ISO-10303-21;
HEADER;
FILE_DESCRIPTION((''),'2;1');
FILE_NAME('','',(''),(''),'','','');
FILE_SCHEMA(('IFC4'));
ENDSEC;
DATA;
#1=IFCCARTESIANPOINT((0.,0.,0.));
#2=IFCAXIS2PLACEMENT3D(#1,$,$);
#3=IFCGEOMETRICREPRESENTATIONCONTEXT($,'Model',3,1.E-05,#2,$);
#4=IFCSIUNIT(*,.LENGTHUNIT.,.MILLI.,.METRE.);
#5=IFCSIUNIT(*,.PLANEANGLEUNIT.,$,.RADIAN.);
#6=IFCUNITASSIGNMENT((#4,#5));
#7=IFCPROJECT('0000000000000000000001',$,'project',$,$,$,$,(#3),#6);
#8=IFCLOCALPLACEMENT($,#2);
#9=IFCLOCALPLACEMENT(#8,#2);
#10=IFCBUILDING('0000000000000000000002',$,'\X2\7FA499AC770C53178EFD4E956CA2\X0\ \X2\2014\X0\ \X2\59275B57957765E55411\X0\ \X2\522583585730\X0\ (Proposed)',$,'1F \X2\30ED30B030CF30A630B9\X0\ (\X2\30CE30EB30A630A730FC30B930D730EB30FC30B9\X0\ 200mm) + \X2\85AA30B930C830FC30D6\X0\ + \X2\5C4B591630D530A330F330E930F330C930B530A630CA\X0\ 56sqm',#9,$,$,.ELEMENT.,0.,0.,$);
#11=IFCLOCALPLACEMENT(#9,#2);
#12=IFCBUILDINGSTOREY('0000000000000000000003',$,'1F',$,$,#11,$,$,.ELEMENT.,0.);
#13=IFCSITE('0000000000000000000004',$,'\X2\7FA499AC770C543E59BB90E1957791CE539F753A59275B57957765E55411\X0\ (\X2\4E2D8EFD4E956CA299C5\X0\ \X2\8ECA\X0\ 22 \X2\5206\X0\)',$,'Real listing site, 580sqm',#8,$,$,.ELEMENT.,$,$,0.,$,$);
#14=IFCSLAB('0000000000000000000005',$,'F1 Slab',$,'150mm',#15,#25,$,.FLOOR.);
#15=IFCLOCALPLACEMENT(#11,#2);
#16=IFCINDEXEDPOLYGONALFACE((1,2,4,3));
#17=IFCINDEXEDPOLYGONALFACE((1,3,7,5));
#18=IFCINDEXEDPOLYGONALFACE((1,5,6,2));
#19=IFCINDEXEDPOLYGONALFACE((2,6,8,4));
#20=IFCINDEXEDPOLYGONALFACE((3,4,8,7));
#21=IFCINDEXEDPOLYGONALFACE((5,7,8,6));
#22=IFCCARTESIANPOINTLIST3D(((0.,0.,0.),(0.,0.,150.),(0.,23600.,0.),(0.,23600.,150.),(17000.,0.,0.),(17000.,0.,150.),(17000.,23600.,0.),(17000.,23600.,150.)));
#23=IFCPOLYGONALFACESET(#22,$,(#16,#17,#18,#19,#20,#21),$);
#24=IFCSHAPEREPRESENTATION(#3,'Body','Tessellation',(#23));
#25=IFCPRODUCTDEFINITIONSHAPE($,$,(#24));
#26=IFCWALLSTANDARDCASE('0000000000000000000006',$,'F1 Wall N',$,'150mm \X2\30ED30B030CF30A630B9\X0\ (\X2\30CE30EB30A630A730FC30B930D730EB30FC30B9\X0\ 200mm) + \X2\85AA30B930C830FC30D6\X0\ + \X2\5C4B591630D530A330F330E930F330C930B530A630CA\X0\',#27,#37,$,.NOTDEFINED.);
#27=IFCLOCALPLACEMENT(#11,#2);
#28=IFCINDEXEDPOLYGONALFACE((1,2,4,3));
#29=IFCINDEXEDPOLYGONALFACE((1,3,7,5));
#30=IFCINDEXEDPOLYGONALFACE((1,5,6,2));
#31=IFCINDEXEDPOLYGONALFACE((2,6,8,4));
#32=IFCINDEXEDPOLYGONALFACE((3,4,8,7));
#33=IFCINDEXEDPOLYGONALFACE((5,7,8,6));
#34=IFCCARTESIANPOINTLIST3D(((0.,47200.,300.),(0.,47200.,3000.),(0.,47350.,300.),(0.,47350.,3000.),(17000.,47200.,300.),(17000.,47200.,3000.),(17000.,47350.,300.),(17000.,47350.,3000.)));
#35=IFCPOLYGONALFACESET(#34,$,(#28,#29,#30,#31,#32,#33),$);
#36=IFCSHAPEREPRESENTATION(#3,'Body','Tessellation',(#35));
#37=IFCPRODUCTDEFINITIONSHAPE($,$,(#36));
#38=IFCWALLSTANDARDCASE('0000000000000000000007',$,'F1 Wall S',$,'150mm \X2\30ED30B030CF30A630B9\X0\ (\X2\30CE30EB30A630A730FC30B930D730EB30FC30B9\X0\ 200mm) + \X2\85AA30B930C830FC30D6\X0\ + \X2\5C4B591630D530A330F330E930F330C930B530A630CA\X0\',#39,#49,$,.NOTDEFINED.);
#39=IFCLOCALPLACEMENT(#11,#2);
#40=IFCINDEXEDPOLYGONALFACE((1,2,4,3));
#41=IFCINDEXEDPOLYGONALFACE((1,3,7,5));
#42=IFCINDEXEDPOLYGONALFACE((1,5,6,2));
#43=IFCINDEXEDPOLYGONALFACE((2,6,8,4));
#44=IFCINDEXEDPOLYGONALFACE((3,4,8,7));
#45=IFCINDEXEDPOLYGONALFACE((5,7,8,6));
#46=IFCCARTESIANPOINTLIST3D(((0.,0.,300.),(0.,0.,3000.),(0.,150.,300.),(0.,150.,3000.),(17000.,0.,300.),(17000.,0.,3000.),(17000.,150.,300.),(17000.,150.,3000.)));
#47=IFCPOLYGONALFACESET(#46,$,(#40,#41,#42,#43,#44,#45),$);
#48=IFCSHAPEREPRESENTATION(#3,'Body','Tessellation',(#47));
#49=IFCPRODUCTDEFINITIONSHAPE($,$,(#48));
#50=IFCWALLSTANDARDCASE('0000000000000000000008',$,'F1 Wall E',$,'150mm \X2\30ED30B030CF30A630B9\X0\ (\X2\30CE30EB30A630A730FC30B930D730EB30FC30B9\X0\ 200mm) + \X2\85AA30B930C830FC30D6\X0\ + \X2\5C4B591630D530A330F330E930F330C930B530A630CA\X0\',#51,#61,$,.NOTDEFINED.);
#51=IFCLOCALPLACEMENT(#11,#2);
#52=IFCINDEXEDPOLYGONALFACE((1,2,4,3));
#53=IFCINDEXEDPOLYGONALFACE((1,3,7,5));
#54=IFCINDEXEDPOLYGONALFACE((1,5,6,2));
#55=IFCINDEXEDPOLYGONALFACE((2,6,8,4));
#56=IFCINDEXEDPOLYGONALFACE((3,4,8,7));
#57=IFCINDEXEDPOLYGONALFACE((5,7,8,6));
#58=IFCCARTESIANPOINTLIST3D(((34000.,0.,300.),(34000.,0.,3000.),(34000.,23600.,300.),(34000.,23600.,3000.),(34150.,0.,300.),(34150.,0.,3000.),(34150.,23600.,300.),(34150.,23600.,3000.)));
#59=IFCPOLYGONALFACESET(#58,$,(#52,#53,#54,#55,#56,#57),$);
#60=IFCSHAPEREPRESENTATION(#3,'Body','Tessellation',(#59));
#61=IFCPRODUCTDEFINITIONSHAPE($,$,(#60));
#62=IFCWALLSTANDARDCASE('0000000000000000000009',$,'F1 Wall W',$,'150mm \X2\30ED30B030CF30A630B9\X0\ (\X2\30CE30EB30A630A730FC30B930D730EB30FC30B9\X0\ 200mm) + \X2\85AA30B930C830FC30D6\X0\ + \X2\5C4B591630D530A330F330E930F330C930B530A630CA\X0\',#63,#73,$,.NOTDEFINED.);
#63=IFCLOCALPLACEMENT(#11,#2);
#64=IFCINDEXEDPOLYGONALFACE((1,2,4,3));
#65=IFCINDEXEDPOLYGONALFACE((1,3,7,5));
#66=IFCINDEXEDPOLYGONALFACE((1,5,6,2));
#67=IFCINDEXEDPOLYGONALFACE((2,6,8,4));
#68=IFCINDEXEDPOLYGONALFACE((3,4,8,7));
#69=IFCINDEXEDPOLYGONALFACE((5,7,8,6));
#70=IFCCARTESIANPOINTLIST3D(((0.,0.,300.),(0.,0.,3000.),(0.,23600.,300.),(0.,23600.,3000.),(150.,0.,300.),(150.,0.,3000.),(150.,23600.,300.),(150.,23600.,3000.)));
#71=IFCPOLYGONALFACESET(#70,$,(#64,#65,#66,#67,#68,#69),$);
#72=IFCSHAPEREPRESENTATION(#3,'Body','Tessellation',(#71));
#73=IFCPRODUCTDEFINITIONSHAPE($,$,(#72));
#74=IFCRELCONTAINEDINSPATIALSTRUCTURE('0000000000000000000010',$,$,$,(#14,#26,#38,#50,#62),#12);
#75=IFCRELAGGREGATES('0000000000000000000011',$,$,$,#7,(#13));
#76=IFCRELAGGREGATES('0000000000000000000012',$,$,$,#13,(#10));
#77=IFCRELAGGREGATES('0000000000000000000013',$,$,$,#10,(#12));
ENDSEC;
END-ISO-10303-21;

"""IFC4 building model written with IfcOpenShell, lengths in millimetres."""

from ifc_helpers import new_model, si_unit, frame, frame_2d, origin, place, context, project, spatial, rectangle, extrude, element, save


model = new_model("IFC4")

# Units and contexts
model_context = context("Model", 3, precision=1e-05, world=origin())
ifc_project = project(units=[si_unit("LENGTHUNIT", "METRE", prefix="MILLI"), si_unit("PLANEANGLEUNIT", "RADIAN")], contexts=[model_context])

# Site, building, storey
site_placement = place(None, origin())
site = spatial("IfcSite", under=ifc_project, at=site_placement, Name="群馬県吾妻郡長野原町大字長日向 (中軽井沢駅 車 22 分)", ObjectType="Real listing site, 580sqm", CompositionType="ELEMENT", RefElevation=0.0)
building_placement = place(site_placement, origin())
building = spatial("IfcBuilding", under=site, at=building_placement, Name="群馬県北軽井沢 — 大字長日向 別荘地 (Proposed)", ObjectType="1F ログハウス (ノルウェースプルース 200mm) + 薪ストーブ + 屋外フィンランドサウナ 56sqm", CompositionType="ELEMENT", ElevationOfRefHeight=0.0, ElevationOfTerrain=0.0)
storey_placement = place(building_placement, origin())
storey = spatial("IfcBuildingStorey", under=building, at=storey_placement, Name="1F", CompositionType="ELEMENT", Elevation=0.0)

# Slab
slab_placement = place(storey_placement, origin())
element("IfcSlab", 1, at=slab_placement, inside=storey, Name="F1 Slab", ObjectType="150mm", PredefinedType="FLOOR", context=model_context, shape_type="SweptSolid", body=[
    extrude(rectangle(XDim=17000.0, YDim=23600.0, at=frame_2d((8500.0, 11800.0))), origin(), (0.0, 0.0, 1.0), 150.0),
])

# Walls
wall_1_placement = place(storey_placement, frame((0.0, 23600.0, 150.0)))
element("IfcWallStandardCase", 2, at=wall_1_placement, inside=storey, Name="F1 Wall N", ObjectType="150mm ログハウス (ノルウェースプルース 200mm) + 薪ストーブ + 屋外フィンランドサウナ", PredefinedType="NOTDEFINED", context=model_context, shape_type="SweptSolid", body=[
    extrude(rectangle(XDim=17000.0, YDim=150.0, at=frame_2d((8500.0, 75.0))), frame((0.0, 23600.0, 150.0)), (0.0, 0.0, 1.0), 2700.0),
])
wall_2_placement = place(storey_placement, frame((0.0, 0.0, 150.0)))
element("IfcWallStandardCase", 3, at=wall_2_placement, inside=storey, Name="F1 Wall S", ObjectType="150mm ログハウス (ノルウェースプルース 200mm) + 薪ストーブ + 屋外フィンランドサウナ", PredefinedType="NOTDEFINED", context=model_context, shape_type="SweptSolid", body=[
    extrude(rectangle(XDim=17000.0, YDim=150.0, at=frame_2d((8500.0, 75.0))), frame((0.0, 0.0, 150.0)), (0.0, 0.0, 1.0), 2700.0),
])
wall_3_placement = place(storey_placement, frame((17000.0, 0.0, 150.0)))
element("IfcWallStandardCase", 4, at=wall_3_placement, inside=storey, Name="F1 Wall E", ObjectType="150mm ログハウス (ノルウェースプルース 200mm) + 薪ストーブ + 屋外フィンランドサウナ", PredefinedType="NOTDEFINED", context=model_context, shape_type="SweptSolid", body=[
    extrude(rectangle(XDim=150.0, YDim=23600.0, at=frame_2d((75.0, 11800.0))), frame((17000.0, 0.0, 150.0)), (0.0, 0.0, 1.0), 2700.0),
])
wall_4_placement = place(storey_placement, frame((0.0, 0.0, 150.0)))
element("IfcWallStandardCase", 5, at=wall_4_placement, inside=storey, Name="F1 Wall W", ObjectType="150mm ログハウス (ノルウェースプルース 200mm) + 薪ストーブ + 屋外フィンランドサウナ", PredefinedType="NOTDEFINED", context=model_context, shape_type="SweptSolid", body=[
    extrude(rectangle(XDim=150.0, YDim=23600.0, at=frame_2d((75.0, 11800.0))), frame((0.0, 0.0, 150.0)), (0.0, 0.0, 1.0), 2700.0),
])

save(model, "model.ifc")
